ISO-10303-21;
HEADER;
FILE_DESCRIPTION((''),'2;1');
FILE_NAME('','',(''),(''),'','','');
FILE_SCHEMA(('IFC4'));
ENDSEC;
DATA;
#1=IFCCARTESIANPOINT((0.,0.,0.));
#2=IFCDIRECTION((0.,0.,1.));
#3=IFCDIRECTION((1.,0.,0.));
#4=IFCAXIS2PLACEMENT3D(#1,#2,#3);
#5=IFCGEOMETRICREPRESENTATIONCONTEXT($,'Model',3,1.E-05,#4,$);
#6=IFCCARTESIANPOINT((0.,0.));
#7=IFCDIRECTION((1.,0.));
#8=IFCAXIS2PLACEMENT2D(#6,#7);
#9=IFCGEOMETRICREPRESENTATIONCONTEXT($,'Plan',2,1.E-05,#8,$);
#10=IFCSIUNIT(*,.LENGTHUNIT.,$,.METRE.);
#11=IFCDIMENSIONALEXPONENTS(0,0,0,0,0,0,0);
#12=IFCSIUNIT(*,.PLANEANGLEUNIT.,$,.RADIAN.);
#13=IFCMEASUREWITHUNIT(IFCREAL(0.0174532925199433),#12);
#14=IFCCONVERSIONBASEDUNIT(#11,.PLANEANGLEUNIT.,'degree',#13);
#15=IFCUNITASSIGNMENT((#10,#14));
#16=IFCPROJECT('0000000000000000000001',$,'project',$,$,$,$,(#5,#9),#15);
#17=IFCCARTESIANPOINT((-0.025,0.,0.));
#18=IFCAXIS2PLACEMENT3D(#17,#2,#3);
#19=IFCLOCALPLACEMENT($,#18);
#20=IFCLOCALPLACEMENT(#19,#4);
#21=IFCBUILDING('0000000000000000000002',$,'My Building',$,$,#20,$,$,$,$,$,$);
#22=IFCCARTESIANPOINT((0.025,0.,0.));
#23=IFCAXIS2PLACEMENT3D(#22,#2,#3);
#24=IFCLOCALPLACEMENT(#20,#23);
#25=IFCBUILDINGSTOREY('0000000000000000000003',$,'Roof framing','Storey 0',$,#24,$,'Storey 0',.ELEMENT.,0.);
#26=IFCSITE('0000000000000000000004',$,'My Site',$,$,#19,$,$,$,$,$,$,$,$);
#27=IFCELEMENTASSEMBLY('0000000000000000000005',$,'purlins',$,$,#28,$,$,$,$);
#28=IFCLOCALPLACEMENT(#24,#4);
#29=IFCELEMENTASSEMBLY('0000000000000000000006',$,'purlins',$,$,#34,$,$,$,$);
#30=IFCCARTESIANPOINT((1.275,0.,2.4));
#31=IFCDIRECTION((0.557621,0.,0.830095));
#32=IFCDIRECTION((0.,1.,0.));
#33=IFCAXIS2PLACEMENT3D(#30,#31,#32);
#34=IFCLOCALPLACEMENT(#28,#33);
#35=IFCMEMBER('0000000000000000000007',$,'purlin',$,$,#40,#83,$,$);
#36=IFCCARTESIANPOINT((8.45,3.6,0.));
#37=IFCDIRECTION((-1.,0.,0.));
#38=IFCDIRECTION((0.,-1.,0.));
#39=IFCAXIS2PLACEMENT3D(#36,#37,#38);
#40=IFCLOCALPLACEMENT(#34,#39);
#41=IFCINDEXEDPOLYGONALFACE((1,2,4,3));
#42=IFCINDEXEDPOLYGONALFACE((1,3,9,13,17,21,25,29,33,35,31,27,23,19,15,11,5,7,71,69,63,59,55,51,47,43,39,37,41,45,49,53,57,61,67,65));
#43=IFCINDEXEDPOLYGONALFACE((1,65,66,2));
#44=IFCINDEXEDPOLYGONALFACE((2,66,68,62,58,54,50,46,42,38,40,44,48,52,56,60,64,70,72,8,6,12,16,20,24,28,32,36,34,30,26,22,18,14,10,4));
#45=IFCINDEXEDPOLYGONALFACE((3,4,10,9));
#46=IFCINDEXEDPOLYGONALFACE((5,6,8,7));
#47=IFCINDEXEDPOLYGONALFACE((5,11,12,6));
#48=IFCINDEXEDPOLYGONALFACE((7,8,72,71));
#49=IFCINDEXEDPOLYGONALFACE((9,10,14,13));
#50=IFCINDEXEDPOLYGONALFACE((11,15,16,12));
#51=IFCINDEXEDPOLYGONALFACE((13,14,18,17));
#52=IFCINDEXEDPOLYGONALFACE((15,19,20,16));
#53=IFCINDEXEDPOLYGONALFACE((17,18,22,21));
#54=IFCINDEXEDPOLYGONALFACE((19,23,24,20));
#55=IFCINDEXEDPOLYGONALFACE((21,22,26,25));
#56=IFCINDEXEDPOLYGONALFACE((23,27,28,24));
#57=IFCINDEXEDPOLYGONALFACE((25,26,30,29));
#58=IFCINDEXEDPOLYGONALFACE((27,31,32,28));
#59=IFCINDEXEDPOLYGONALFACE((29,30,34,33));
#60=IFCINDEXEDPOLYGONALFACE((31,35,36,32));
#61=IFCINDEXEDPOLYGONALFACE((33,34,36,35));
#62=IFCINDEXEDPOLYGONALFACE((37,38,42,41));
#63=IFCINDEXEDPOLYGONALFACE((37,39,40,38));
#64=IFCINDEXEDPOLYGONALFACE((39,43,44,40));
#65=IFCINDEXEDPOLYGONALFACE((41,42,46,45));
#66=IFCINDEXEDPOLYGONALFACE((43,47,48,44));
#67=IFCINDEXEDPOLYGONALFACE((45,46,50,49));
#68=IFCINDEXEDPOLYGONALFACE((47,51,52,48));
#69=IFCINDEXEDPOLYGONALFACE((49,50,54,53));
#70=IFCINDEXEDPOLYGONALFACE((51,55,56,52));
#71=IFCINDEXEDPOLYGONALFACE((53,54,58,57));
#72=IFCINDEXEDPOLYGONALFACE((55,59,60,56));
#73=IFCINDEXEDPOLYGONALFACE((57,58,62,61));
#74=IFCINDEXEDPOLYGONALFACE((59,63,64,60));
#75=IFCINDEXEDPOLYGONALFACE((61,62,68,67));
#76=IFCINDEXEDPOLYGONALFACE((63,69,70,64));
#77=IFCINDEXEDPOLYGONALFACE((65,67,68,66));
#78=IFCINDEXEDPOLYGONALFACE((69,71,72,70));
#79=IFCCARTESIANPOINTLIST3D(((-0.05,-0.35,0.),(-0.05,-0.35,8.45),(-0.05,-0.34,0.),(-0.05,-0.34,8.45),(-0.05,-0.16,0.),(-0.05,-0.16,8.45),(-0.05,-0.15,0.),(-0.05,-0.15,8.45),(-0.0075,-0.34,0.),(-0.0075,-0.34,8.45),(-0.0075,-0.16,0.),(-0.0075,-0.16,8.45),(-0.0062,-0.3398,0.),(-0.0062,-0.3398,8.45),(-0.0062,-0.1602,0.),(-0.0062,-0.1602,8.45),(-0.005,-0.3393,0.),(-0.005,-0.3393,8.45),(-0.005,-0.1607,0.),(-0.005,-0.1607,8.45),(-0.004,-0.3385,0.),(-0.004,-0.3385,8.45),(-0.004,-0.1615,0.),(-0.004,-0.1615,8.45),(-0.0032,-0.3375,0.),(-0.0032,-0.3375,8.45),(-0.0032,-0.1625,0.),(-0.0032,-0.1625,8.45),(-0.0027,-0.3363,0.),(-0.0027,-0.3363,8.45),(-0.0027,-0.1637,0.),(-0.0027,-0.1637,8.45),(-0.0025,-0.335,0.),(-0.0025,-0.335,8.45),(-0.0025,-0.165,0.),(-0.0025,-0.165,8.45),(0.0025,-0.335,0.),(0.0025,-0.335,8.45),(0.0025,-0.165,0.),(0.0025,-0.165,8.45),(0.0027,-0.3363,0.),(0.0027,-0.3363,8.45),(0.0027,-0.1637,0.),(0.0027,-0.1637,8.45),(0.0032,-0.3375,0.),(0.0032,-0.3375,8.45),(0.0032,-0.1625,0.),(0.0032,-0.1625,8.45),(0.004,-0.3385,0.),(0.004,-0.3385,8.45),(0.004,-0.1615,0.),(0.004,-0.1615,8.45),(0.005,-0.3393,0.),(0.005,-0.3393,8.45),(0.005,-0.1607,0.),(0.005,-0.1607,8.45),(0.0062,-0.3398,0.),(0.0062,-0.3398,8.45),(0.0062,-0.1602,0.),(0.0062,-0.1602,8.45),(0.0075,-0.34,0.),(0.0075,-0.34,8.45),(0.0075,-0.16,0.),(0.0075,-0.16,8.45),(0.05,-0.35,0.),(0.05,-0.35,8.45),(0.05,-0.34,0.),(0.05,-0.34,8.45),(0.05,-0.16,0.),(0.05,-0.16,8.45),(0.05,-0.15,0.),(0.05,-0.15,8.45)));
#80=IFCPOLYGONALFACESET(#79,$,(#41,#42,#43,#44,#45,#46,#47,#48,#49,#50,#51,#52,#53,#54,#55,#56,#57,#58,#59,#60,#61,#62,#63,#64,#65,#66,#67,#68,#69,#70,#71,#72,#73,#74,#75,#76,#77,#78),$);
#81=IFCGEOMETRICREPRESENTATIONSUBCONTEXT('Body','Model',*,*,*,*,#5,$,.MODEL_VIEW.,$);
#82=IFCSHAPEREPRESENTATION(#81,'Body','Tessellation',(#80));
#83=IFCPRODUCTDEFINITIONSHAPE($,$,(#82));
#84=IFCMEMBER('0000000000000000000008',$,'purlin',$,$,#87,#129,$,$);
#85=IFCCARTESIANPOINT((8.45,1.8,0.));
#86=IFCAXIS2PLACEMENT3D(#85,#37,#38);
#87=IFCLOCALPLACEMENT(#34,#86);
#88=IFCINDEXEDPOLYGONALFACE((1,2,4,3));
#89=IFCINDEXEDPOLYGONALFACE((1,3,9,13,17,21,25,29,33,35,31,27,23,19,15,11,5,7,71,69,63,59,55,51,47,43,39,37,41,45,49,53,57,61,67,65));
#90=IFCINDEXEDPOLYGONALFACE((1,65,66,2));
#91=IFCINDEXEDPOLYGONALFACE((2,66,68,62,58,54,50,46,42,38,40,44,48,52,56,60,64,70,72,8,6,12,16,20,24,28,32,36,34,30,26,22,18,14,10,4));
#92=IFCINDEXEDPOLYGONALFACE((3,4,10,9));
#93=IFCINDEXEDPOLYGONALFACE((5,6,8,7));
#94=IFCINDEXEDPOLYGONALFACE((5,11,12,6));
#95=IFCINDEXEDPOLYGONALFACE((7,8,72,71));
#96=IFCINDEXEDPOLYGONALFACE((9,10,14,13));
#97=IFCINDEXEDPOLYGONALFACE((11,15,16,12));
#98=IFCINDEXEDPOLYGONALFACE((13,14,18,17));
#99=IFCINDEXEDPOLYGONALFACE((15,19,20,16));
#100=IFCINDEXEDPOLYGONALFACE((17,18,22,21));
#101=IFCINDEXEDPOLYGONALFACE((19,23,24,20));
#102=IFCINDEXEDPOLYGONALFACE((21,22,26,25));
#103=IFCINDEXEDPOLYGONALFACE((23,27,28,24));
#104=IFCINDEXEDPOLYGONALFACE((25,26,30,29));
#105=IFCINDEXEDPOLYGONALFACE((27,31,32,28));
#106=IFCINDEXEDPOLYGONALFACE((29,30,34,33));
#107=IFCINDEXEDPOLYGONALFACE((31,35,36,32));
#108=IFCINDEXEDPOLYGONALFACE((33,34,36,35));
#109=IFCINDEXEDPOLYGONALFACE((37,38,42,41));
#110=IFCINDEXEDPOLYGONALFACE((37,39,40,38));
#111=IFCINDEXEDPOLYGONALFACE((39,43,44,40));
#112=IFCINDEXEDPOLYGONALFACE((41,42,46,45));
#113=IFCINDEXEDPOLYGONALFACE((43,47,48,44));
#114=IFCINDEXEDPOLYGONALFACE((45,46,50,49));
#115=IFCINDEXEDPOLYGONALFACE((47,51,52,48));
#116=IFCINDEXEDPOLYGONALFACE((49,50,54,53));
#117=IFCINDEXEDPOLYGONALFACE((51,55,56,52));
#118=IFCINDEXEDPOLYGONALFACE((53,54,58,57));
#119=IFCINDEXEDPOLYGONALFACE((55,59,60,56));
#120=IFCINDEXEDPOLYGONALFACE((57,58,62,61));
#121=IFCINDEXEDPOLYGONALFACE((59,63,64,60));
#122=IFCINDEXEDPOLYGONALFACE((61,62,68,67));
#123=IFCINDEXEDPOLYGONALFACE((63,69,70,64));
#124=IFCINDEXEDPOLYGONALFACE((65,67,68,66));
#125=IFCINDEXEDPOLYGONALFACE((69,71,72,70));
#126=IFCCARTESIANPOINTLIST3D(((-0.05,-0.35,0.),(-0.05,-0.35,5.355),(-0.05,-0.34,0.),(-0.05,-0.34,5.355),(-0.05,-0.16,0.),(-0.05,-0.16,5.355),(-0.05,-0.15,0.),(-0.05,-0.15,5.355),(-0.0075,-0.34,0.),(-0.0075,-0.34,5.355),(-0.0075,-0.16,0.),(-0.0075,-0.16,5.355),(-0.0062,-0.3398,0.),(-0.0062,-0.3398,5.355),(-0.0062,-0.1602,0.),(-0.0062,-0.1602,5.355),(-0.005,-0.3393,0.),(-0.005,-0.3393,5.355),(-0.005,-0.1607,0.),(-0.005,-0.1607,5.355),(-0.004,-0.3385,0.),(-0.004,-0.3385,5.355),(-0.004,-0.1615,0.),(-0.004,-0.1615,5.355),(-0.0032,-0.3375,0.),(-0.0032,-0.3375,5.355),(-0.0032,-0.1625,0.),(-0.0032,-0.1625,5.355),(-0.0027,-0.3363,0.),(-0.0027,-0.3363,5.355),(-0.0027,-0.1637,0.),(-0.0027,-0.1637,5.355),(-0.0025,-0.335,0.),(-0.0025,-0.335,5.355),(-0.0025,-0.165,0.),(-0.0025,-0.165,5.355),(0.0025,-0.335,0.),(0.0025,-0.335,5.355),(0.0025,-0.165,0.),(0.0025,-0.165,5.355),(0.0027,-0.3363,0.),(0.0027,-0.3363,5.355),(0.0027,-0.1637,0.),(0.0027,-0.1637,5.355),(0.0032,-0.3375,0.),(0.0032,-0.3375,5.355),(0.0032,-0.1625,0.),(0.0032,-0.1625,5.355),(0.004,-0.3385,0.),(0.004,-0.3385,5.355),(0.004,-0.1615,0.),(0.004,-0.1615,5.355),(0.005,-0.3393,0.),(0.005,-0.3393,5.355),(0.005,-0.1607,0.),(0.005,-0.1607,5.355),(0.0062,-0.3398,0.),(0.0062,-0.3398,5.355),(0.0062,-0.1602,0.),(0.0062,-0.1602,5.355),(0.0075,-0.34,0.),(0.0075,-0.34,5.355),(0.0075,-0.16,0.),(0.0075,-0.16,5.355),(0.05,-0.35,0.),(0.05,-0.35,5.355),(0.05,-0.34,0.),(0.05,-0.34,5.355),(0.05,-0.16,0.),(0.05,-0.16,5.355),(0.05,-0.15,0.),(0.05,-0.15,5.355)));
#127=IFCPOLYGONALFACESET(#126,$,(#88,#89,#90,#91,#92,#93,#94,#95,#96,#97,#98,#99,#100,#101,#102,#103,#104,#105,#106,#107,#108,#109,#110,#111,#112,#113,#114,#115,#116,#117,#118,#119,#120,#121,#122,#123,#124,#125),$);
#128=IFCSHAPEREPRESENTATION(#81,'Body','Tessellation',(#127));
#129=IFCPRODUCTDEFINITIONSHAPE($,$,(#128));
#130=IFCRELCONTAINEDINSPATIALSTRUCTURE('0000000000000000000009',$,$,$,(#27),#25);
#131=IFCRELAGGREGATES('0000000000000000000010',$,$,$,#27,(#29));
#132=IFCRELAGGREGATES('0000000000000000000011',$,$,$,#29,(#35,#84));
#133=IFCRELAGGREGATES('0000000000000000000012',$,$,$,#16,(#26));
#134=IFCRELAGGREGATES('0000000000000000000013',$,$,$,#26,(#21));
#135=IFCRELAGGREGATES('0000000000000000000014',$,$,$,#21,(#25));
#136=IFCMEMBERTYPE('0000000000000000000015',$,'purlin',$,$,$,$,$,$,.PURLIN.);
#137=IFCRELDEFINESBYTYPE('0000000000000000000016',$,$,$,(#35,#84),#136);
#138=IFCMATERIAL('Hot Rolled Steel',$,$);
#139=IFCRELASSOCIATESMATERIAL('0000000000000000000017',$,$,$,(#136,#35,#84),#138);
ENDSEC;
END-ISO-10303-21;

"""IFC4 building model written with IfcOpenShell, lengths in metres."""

from ifc_helpers import new_model, entity, si_unit, converted_unit, frame, frame_2d, origin_with_axes, origin_2d_with_axis, place, context, subcontext, project, spatial, i_section, extrude, material, material_profile, profile_set, profile_usage, type_object, element, aggregate, save


model = new_model("IFC4")

# Units and contexts
model_context = context("Model", 3, precision=1e-05, world=origin_with_axes())
plan_context = context("Plan", 2, precision=1e-05, world=origin_2d_with_axis())
body_context = subcontext(model_context, "Body", "Model", "MODEL_VIEW")
ifc_project = project(units=[si_unit("LENGTHUNIT", "METRE"), converted_unit("PLANEANGLEUNIT", "degree", entity("IfcReal", 0.0174532925199433), si_unit("PLANEANGLEUNIT", "RADIAN"), dimensions=[0, 0, 0, 0, 0, 0, 0])], contexts=[model_context, plan_context])

# Site, building, storey
site_placement = place(None, frame((-0.025, 0.0, 0.0), z_axis=(0.0, 0.0, 1.0), x_axis=(1.0, 0.0, 0.0)))
site = spatial("IfcSite", under=ifc_project, at=site_placement, Name="My Site")
building_placement = place(site_placement, origin_with_axes())
building = spatial("IfcBuilding", under=site, at=building_placement, Name="My Building")
storey_placement = place(building_placement, frame((0.025, 0.0, 0.0), z_axis=(0.0, 0.0, 1.0), x_axis=(1.0, 0.0, 0.0)))
storey = spatial("IfcBuildingStorey", under=building, at=storey_placement, Name="Roof framing", Description="Storey 0", LongName="Storey 0", CompositionType="ELEMENT", Elevation=0.0)

# Element assemblies, members
assembly_1_placement = place(storey_placement, origin_with_axes())
assembly_1 = element("IfcElementAssembly", 1, at=assembly_1_placement, inside=storey, Name="purlins")
assembly_2_placement = place(assembly_1_placement, frame((1.275, 0.0, 2.4), z_axis=(0.557621, 0.0, 0.830095), x_axis=(0.0, 1.0, 0.0)))
assembly_2 = element("IfcElementAssembly", 2, at=assembly_2_placement, Name="purlins")
aggregate(assembly_1, [assembly_2])
ifc_material_1 = material(Name="Hot Rolled Steel")
ifc_material_profile_1 = material_profile(ifc_material_1, i_section(OverallWidth=0.1, OverallDepth=0.2, WebThickness=0.005, FlangeThickness=0.01, FilletRadius=0.005, at=frame_2d((0.0, -0.25), x_axis=(1.0, 0.0))))
ifc_profile_set_1 = profile_set([ifc_material_profile_1])
ifc_profile_usage_1 = profile_usage(ifc_profile_set_1)
member_type_1 = type_object("IfcMemberType", Name="purlin", PredefinedType="PURLIN", material=ifc_profile_set_1)
member_1_placement = place(assembly_2_placement, frame((8.45, 3.6, 0.0), z_axis=(-1.0, 0.0, 0.0), x_axis=(0.0, -1.0, 0.0)))
member_1 = element("IfcMember", 3, at=member_1_placement, type_object=member_type_1, material=ifc_profile_usage_1, Name="purlin", context=body_context, shape_type="SweptSolid", body=[
    extrude(i_section(OverallWidth=0.1, OverallDepth=0.2, WebThickness=0.005, FlangeThickness=0.01, FilletRadius=0.005, at=frame_2d((0.0, -0.25), x_axis=(1.0, 0.0))), origin_with_axes(), (0.0, 0.0, 1.0), 8.45),
])
ifc_profile_usage_2 = profile_usage(ifc_profile_set_1)
member_2_placement = place(assembly_2_placement, frame((8.45, 1.8, 0.0), z_axis=(-1.0, 0.0, 0.0), x_axis=(0.0, -1.0, 0.0)))
member_2 = element("IfcMember", 4, at=member_2_placement, type_object=member_type_1, material=ifc_profile_usage_2, Name="purlin", context=body_context, shape_type="SweptSolid", body=[
    extrude(i_section(OverallWidth=0.1, OverallDepth=0.2, WebThickness=0.005, FlangeThickness=0.01, FilletRadius=0.005, at=frame_2d((0.0, -0.25), x_axis=(1.0, 0.0))), origin_with_axes(), (0.0, 0.0, 1.0), 5.355),
])
aggregate(assembly_2, [member_1, member_2])

save(model, "model.ifc")
